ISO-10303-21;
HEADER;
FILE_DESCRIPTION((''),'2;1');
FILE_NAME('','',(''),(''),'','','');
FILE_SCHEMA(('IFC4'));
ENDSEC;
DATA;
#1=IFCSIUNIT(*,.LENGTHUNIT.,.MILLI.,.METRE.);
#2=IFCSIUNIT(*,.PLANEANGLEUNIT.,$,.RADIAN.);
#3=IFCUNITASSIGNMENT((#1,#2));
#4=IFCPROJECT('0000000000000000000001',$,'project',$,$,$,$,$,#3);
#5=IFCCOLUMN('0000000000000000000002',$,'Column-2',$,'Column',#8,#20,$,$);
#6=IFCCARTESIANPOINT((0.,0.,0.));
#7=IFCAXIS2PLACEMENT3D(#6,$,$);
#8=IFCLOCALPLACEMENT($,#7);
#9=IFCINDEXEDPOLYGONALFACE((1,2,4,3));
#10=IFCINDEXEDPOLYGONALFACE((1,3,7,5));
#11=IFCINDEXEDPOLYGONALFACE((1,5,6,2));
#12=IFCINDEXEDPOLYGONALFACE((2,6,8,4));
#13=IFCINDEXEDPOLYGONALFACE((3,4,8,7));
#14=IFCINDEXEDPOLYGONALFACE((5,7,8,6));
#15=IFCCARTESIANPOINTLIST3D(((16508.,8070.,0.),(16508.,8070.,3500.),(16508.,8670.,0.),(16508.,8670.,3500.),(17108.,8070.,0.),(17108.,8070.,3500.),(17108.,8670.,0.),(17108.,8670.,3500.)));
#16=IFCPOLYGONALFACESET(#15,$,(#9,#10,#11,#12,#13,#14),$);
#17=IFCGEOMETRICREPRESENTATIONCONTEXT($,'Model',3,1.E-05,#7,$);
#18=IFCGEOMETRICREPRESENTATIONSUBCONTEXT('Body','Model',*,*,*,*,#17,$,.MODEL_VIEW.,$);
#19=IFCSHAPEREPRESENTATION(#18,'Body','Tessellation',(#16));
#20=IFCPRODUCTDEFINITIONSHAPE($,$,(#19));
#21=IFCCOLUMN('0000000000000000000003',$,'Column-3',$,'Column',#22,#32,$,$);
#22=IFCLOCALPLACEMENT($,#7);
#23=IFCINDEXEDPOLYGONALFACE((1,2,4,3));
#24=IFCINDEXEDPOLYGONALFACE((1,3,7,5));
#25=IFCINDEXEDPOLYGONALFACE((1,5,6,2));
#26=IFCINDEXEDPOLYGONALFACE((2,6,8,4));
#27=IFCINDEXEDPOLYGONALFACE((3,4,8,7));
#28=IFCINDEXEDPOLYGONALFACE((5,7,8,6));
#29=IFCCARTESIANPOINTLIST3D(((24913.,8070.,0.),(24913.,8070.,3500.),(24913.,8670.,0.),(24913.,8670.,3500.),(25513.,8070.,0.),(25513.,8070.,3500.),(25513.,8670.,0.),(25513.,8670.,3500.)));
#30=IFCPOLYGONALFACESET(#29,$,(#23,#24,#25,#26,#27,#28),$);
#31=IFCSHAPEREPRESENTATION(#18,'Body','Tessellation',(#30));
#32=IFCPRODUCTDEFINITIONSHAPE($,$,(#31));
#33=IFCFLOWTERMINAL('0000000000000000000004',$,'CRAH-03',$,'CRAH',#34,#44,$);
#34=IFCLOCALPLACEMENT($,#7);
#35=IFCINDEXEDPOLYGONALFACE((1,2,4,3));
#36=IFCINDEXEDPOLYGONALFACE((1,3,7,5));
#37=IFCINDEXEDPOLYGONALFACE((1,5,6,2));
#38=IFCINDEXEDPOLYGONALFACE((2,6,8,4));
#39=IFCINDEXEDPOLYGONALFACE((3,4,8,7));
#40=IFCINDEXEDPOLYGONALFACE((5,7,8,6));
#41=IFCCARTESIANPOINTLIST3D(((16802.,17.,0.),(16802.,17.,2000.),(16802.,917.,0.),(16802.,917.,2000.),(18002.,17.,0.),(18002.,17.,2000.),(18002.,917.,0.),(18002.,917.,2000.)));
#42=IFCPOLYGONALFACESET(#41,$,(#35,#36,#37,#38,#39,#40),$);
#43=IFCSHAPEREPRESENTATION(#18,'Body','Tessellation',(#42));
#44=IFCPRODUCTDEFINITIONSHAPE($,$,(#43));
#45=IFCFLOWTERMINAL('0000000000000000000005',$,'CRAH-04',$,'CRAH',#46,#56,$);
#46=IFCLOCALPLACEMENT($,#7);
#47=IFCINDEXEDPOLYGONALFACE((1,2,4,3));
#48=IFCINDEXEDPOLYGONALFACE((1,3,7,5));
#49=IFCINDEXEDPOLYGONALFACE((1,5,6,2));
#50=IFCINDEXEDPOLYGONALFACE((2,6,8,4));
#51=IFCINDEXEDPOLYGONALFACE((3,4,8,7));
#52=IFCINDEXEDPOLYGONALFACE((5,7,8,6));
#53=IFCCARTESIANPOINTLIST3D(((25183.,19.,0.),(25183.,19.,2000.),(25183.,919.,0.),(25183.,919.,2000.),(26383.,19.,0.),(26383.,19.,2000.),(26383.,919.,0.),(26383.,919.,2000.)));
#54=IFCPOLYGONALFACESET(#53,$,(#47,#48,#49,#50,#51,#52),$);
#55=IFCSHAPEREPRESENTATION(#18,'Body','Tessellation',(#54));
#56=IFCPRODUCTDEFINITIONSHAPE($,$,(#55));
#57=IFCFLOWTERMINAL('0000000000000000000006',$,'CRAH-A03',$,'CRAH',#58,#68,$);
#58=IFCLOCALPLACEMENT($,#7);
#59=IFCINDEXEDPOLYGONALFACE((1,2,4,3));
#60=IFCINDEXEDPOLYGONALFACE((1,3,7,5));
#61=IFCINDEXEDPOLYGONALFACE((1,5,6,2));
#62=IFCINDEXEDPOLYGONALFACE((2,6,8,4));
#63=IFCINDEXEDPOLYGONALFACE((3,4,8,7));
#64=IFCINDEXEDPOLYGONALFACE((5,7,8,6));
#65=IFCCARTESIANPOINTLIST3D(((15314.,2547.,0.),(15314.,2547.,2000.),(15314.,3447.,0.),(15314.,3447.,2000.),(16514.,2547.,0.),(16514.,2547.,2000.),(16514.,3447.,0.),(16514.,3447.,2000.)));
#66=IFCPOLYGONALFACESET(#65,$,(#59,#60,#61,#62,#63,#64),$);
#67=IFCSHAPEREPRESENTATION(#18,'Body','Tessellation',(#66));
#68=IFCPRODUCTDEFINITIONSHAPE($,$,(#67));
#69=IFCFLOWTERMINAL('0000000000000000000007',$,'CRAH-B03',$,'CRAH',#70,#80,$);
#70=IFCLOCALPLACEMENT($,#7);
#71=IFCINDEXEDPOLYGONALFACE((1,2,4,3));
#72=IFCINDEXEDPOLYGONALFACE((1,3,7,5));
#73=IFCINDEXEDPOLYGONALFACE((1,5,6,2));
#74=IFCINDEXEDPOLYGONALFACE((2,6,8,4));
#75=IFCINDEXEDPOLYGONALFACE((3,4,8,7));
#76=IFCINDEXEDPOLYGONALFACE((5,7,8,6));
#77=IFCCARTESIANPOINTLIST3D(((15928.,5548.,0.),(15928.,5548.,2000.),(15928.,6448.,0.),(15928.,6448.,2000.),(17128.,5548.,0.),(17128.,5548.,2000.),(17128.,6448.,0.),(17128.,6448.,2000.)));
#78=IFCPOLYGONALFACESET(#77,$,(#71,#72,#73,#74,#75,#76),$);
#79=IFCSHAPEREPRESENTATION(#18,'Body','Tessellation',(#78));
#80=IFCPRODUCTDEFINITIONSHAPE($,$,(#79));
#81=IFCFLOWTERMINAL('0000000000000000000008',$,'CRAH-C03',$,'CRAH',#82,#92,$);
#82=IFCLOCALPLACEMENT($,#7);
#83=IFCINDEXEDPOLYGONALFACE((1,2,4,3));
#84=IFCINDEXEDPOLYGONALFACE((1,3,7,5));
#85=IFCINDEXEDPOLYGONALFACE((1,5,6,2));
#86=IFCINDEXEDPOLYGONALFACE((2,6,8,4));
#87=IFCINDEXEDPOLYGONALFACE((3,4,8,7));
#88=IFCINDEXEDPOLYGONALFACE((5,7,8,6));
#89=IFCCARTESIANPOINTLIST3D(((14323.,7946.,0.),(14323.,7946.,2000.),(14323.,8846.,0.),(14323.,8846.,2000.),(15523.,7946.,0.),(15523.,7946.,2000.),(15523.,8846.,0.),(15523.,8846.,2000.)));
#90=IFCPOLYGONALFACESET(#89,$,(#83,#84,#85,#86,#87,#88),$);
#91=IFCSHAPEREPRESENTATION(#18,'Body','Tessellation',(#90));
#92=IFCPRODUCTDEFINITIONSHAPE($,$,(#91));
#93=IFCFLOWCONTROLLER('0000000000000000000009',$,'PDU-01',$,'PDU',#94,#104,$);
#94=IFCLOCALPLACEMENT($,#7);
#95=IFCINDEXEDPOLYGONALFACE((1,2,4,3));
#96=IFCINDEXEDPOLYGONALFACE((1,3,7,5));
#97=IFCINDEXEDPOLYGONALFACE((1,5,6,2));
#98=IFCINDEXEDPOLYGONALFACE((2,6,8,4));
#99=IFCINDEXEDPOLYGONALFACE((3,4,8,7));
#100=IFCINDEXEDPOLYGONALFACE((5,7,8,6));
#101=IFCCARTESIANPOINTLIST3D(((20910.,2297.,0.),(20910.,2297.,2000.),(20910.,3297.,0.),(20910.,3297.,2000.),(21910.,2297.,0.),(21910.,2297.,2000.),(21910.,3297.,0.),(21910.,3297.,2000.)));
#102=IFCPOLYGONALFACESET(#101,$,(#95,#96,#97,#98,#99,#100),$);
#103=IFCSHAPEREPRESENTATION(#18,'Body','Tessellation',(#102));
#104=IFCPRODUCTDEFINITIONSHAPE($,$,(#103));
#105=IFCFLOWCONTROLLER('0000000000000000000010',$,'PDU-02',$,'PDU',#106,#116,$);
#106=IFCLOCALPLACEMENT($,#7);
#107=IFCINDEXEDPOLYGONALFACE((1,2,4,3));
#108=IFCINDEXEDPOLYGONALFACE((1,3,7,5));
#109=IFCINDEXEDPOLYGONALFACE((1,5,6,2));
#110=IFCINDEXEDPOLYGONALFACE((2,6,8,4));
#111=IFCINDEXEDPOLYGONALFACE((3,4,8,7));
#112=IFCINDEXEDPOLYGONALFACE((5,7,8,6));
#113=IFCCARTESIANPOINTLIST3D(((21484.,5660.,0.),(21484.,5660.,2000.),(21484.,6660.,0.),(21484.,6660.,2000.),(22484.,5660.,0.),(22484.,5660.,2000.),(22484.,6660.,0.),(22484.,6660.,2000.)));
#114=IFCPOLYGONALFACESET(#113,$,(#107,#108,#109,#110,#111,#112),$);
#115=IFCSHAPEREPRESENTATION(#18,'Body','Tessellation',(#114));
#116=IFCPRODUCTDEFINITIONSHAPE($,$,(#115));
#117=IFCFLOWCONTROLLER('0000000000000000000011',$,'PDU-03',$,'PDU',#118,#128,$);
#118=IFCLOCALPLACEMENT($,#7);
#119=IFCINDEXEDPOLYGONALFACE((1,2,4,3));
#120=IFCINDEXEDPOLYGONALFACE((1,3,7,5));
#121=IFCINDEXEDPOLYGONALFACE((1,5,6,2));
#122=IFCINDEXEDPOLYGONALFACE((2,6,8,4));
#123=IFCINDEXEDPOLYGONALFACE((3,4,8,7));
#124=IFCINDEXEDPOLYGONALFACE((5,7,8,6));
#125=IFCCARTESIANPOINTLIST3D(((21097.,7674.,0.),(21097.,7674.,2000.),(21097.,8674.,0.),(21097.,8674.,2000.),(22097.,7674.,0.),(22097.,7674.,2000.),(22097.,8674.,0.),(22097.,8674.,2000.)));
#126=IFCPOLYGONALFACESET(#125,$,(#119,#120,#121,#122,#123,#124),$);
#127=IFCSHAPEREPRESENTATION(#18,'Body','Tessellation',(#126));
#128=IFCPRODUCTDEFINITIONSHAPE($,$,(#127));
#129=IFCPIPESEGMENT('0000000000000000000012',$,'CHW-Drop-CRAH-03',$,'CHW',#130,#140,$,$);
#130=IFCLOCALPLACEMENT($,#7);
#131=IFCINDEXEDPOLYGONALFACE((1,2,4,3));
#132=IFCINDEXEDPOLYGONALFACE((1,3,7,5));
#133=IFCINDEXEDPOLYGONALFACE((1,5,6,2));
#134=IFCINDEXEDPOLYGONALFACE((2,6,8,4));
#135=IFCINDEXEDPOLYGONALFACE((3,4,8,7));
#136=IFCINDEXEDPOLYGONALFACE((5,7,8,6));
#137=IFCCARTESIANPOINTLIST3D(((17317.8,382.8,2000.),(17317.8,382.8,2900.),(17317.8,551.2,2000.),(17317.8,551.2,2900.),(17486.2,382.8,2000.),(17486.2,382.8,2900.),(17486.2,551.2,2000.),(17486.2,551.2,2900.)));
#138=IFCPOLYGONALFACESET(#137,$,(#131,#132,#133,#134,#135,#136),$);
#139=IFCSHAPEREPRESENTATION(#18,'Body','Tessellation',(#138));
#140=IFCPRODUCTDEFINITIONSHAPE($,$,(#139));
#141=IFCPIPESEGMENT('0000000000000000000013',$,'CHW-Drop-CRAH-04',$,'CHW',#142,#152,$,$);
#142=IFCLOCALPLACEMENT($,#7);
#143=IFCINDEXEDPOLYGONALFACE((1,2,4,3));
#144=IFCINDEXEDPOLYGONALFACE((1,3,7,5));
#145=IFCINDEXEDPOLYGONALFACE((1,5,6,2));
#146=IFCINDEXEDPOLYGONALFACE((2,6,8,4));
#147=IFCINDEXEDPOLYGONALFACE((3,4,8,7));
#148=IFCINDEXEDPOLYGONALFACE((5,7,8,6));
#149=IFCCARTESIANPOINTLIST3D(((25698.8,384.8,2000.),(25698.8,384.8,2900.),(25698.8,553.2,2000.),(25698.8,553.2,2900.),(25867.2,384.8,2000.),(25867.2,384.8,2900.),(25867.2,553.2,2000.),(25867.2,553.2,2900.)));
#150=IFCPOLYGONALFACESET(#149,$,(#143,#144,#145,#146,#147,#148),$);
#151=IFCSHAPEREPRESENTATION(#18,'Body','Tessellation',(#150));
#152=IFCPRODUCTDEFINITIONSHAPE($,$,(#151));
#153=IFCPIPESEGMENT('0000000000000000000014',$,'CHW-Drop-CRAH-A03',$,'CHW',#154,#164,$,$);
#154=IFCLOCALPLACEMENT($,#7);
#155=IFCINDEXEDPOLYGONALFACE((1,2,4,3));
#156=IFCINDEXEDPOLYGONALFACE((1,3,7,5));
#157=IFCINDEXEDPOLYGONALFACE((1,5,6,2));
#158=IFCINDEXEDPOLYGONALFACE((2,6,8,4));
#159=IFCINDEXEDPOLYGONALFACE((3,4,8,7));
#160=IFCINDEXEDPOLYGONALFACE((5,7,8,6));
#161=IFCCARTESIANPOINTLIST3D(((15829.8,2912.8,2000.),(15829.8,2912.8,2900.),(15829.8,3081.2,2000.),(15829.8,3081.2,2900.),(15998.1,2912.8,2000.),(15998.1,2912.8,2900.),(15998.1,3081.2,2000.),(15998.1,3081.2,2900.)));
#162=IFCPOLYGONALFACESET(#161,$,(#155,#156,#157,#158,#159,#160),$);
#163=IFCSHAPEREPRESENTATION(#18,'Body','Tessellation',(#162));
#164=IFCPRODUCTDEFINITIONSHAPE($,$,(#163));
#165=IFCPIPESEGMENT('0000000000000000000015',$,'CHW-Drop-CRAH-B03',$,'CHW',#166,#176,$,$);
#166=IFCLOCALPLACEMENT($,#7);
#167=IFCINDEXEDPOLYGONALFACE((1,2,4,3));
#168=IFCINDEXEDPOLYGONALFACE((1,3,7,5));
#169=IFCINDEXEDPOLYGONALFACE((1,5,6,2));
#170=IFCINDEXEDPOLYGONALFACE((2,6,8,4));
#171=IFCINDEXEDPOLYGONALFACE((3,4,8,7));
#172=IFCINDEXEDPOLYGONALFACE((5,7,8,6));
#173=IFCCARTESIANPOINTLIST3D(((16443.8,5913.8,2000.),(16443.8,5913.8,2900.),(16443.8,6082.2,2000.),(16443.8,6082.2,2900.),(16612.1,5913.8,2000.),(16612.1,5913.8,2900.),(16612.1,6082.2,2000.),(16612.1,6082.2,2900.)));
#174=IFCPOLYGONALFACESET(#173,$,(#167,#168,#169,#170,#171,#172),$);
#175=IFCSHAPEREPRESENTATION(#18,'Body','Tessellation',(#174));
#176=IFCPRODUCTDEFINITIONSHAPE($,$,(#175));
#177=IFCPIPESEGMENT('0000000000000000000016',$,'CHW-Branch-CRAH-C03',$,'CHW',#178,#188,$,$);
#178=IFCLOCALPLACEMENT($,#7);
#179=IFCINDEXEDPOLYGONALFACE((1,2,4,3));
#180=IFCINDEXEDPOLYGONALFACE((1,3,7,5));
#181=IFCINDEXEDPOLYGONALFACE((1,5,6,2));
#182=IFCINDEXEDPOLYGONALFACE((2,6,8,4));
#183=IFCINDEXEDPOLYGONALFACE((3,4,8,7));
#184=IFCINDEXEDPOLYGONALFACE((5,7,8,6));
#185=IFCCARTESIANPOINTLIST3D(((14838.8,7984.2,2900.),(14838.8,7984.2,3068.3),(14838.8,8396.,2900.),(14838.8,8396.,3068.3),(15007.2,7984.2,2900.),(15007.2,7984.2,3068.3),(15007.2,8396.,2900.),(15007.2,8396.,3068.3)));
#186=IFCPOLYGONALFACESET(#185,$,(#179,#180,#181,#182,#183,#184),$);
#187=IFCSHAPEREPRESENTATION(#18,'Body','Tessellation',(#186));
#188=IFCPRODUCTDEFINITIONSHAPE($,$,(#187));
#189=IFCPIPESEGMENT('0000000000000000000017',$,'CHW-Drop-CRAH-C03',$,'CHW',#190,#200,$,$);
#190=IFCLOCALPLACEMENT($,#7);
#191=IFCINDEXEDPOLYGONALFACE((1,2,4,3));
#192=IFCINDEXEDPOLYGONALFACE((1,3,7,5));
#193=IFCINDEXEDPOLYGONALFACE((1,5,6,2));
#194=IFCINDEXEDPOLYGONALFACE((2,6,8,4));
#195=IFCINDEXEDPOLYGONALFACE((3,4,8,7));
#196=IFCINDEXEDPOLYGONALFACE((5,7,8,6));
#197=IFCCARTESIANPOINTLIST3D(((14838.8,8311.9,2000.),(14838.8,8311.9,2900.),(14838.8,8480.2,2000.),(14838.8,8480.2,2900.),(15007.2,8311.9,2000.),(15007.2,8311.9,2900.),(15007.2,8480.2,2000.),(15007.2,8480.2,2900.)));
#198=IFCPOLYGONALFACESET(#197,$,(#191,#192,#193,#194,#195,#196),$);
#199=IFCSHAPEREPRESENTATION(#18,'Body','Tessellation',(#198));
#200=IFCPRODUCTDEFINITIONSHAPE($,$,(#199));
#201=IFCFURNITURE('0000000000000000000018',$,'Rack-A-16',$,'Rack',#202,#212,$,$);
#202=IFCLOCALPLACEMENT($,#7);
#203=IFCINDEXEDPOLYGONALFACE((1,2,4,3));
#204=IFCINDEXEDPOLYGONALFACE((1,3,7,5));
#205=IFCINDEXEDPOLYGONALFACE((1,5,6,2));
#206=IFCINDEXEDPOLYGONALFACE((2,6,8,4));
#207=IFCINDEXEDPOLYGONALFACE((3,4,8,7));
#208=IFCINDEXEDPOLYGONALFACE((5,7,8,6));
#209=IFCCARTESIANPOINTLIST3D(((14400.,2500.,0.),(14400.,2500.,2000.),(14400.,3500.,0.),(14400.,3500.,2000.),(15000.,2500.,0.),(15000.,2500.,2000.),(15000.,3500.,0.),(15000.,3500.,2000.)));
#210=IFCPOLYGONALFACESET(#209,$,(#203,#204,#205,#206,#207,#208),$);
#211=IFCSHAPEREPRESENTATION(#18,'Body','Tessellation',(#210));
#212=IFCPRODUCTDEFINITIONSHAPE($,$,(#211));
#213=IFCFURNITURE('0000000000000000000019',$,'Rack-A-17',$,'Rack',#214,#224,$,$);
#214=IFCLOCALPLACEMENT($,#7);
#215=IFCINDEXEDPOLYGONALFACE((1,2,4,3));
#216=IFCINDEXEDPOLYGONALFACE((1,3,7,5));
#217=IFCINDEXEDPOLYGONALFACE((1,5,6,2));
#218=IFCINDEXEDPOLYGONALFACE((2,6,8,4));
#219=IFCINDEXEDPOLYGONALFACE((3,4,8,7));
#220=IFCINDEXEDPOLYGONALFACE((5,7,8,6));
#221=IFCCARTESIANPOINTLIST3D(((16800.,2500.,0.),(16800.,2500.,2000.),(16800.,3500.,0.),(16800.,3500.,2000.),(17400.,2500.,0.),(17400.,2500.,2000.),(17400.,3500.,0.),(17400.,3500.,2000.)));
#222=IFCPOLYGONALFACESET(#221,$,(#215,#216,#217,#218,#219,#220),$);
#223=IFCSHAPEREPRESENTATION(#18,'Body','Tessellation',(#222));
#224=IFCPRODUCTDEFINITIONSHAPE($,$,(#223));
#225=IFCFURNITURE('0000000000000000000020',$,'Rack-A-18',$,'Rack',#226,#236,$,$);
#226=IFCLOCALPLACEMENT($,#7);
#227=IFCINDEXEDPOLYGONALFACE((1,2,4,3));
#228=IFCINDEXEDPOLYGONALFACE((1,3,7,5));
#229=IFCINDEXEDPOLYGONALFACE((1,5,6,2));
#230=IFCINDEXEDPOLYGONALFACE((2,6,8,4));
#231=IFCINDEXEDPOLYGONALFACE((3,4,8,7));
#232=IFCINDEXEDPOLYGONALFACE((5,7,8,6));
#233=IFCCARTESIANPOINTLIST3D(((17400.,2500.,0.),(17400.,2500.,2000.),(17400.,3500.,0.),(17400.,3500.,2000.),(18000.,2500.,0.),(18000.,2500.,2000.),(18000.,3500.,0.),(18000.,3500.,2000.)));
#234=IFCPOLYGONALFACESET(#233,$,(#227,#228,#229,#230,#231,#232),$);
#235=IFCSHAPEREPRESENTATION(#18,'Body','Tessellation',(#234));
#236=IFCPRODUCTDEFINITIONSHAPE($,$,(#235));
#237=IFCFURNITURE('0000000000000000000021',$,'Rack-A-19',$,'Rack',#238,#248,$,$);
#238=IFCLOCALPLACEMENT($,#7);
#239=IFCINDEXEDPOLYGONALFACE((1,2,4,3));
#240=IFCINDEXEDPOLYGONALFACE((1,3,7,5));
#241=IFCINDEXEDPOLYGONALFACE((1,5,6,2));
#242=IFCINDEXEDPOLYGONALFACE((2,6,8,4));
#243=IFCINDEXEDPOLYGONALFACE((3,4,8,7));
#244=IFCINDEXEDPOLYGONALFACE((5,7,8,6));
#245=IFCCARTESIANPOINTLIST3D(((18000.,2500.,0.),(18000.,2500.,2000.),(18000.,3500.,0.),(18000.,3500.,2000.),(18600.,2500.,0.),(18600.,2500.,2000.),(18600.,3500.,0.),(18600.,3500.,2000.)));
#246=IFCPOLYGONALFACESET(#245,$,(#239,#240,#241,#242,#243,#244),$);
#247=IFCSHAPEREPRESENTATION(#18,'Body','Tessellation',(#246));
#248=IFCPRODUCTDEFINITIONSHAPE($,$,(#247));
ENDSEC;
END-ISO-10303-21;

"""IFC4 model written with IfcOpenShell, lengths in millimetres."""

from ifc_helpers import new_model, si_unit, frame, origin, place, context, subcontext, project, rectangle, extrude, element, save


model = new_model("IFC4")

# Units and contexts
model_context = context("Model", 3, precision=1e-05, world=origin())
body_context = subcontext(model_context, "Body", "Model", "MODEL_VIEW")
ifc_project = project(units=[si_unit("LENGTHUNIT", "METRE", prefix="MILLI"), si_unit("PLANEANGLEUNIT", "RADIAN")])

# Columns
for number, where, name in (
    (1, (16808.0, 8370.0, 0.0), "Column-2"),
    (2, (25213.0, 8370.0, 0.0), "Column-3"),
):
    element("IfcColumn", number, at=place(None, frame(where)), Name=name, ObjectType="Column", context=body_context, shape_type="SweptSolid", body=[
        extrude(rectangle(XDim=600.0, YDim=600.0), None, (0.0, 0.0, 1.0), 3500.0),
    ])

# Flow terminals
for number, where, name in (
    (3, (17402.0, 467.0, 0.0), "CRAH-03"),
    (4, (25783.0, 469.0, 0.0), "CRAH-04"),
    (5, (15914.0, 2997.0, 0.0), "CRAH-A03"),
    (6, (16528.0, 5998.0, 0.0), "CRAH-B03"),
    (7, (14923.0, 8396.0, 0.0), "CRAH-C03"),
):
    element("IfcFlowTerminal", number, at=place(None, frame(where)), Name=name, ObjectType="CRAH", context=body_context, shape_type="SweptSolid", body=[
        extrude(rectangle(XDim=1200.0, YDim=900.0), None, (0.0, 0.0, 1.0), 2000.0),
    ])

# Flow controllers
for number, where, name in (
    (8, (21410.0, 2797.0, 0.0), "PDU-01"),
    (9, (21984.0, 6160.0, 0.0), "PDU-02"),
    (10, (21597.0, 8174.0, 0.0), "PDU-03"),
):
    element("IfcFlowController", number, at=place(None, frame(where)), Name=name, ObjectType="PDU", context=body_context, shape_type="SweptSolid", body=[
        extrude(rectangle(XDim=1000.0, YDim=1000.0), None, (0.0, 0.0, 1.0), 2000.0),
    ])

# Pipe segments
for number, where, name in (
    (11, (17402.0, 467.0, 2000.0), "CHW-Drop-CRAH-03"),
    (12, (25783.0, 469.0, 2000.0), "CHW-Drop-CRAH-04"),
    (13, (15914.0, 2997.0, 2000.0), "CHW-Drop-CRAH-A03"),
    (14, (16528.0, 5998.0, 2000.0), "CHW-Drop-CRAH-B03"),
):
    element("IfcPipeSegment", number, at=place(None, frame(where)), Name=name, ObjectType="CHW", context=body_context, shape_type="SweptSolid", body=[
        extrude(rectangle(XDim=168.3, YDim=168.3), None, (0.0, 0.0, 1.0), 900.0),
    ])
pipe_segment_1_placement = place(None, frame((14923.0, 8190.1, 2900.0)))
element("IfcPipeSegment", 15, at=pipe_segment_1_placement, Name="CHW-Branch-CRAH-C03", ObjectType="CHW", context=body_context, shape_type="SweptSolid", body=[
    extrude(rectangle(XDim=168.3, YDim=411.9), None, (0.0, 0.0, 1.0), 168.3),
])
pipe_segment_2_placement = place(None, frame((14923.0, 8396.0, 2000.0)))
element("IfcPipeSegment", 16, at=pipe_segment_2_placement, Name="CHW-Drop-CRAH-C03", ObjectType="CHW", context=body_context, shape_type="SweptSolid", body=[
    extrude(rectangle(XDim=168.3, YDim=168.3), None, (0.0, 0.0, 1.0), 900.0),
])

# Furniture
for number, where, name in (
    (17, (14700.0, 3000.0, 0.0), "Rack-A-16"),
    (18, (17100.0, 3000.0, 0.0), "Rack-A-17"),
    (19, (17700.0, 3000.0, 0.0), "Rack-A-18"),
    (20, (18300.0, 3000.0, 0.0), "Rack-A-19"),
):
    element("IfcFurniture", number, at=place(None, frame(where)), Name=name, ObjectType="Rack", context=body_context, shape_type="SweptSolid", body=[
        extrude(rectangle(XDim=600.0, YDim=1000.0), None, (0.0, 0.0, 1.0), 2000.0),
    ])

save(model, "model.ifc")
